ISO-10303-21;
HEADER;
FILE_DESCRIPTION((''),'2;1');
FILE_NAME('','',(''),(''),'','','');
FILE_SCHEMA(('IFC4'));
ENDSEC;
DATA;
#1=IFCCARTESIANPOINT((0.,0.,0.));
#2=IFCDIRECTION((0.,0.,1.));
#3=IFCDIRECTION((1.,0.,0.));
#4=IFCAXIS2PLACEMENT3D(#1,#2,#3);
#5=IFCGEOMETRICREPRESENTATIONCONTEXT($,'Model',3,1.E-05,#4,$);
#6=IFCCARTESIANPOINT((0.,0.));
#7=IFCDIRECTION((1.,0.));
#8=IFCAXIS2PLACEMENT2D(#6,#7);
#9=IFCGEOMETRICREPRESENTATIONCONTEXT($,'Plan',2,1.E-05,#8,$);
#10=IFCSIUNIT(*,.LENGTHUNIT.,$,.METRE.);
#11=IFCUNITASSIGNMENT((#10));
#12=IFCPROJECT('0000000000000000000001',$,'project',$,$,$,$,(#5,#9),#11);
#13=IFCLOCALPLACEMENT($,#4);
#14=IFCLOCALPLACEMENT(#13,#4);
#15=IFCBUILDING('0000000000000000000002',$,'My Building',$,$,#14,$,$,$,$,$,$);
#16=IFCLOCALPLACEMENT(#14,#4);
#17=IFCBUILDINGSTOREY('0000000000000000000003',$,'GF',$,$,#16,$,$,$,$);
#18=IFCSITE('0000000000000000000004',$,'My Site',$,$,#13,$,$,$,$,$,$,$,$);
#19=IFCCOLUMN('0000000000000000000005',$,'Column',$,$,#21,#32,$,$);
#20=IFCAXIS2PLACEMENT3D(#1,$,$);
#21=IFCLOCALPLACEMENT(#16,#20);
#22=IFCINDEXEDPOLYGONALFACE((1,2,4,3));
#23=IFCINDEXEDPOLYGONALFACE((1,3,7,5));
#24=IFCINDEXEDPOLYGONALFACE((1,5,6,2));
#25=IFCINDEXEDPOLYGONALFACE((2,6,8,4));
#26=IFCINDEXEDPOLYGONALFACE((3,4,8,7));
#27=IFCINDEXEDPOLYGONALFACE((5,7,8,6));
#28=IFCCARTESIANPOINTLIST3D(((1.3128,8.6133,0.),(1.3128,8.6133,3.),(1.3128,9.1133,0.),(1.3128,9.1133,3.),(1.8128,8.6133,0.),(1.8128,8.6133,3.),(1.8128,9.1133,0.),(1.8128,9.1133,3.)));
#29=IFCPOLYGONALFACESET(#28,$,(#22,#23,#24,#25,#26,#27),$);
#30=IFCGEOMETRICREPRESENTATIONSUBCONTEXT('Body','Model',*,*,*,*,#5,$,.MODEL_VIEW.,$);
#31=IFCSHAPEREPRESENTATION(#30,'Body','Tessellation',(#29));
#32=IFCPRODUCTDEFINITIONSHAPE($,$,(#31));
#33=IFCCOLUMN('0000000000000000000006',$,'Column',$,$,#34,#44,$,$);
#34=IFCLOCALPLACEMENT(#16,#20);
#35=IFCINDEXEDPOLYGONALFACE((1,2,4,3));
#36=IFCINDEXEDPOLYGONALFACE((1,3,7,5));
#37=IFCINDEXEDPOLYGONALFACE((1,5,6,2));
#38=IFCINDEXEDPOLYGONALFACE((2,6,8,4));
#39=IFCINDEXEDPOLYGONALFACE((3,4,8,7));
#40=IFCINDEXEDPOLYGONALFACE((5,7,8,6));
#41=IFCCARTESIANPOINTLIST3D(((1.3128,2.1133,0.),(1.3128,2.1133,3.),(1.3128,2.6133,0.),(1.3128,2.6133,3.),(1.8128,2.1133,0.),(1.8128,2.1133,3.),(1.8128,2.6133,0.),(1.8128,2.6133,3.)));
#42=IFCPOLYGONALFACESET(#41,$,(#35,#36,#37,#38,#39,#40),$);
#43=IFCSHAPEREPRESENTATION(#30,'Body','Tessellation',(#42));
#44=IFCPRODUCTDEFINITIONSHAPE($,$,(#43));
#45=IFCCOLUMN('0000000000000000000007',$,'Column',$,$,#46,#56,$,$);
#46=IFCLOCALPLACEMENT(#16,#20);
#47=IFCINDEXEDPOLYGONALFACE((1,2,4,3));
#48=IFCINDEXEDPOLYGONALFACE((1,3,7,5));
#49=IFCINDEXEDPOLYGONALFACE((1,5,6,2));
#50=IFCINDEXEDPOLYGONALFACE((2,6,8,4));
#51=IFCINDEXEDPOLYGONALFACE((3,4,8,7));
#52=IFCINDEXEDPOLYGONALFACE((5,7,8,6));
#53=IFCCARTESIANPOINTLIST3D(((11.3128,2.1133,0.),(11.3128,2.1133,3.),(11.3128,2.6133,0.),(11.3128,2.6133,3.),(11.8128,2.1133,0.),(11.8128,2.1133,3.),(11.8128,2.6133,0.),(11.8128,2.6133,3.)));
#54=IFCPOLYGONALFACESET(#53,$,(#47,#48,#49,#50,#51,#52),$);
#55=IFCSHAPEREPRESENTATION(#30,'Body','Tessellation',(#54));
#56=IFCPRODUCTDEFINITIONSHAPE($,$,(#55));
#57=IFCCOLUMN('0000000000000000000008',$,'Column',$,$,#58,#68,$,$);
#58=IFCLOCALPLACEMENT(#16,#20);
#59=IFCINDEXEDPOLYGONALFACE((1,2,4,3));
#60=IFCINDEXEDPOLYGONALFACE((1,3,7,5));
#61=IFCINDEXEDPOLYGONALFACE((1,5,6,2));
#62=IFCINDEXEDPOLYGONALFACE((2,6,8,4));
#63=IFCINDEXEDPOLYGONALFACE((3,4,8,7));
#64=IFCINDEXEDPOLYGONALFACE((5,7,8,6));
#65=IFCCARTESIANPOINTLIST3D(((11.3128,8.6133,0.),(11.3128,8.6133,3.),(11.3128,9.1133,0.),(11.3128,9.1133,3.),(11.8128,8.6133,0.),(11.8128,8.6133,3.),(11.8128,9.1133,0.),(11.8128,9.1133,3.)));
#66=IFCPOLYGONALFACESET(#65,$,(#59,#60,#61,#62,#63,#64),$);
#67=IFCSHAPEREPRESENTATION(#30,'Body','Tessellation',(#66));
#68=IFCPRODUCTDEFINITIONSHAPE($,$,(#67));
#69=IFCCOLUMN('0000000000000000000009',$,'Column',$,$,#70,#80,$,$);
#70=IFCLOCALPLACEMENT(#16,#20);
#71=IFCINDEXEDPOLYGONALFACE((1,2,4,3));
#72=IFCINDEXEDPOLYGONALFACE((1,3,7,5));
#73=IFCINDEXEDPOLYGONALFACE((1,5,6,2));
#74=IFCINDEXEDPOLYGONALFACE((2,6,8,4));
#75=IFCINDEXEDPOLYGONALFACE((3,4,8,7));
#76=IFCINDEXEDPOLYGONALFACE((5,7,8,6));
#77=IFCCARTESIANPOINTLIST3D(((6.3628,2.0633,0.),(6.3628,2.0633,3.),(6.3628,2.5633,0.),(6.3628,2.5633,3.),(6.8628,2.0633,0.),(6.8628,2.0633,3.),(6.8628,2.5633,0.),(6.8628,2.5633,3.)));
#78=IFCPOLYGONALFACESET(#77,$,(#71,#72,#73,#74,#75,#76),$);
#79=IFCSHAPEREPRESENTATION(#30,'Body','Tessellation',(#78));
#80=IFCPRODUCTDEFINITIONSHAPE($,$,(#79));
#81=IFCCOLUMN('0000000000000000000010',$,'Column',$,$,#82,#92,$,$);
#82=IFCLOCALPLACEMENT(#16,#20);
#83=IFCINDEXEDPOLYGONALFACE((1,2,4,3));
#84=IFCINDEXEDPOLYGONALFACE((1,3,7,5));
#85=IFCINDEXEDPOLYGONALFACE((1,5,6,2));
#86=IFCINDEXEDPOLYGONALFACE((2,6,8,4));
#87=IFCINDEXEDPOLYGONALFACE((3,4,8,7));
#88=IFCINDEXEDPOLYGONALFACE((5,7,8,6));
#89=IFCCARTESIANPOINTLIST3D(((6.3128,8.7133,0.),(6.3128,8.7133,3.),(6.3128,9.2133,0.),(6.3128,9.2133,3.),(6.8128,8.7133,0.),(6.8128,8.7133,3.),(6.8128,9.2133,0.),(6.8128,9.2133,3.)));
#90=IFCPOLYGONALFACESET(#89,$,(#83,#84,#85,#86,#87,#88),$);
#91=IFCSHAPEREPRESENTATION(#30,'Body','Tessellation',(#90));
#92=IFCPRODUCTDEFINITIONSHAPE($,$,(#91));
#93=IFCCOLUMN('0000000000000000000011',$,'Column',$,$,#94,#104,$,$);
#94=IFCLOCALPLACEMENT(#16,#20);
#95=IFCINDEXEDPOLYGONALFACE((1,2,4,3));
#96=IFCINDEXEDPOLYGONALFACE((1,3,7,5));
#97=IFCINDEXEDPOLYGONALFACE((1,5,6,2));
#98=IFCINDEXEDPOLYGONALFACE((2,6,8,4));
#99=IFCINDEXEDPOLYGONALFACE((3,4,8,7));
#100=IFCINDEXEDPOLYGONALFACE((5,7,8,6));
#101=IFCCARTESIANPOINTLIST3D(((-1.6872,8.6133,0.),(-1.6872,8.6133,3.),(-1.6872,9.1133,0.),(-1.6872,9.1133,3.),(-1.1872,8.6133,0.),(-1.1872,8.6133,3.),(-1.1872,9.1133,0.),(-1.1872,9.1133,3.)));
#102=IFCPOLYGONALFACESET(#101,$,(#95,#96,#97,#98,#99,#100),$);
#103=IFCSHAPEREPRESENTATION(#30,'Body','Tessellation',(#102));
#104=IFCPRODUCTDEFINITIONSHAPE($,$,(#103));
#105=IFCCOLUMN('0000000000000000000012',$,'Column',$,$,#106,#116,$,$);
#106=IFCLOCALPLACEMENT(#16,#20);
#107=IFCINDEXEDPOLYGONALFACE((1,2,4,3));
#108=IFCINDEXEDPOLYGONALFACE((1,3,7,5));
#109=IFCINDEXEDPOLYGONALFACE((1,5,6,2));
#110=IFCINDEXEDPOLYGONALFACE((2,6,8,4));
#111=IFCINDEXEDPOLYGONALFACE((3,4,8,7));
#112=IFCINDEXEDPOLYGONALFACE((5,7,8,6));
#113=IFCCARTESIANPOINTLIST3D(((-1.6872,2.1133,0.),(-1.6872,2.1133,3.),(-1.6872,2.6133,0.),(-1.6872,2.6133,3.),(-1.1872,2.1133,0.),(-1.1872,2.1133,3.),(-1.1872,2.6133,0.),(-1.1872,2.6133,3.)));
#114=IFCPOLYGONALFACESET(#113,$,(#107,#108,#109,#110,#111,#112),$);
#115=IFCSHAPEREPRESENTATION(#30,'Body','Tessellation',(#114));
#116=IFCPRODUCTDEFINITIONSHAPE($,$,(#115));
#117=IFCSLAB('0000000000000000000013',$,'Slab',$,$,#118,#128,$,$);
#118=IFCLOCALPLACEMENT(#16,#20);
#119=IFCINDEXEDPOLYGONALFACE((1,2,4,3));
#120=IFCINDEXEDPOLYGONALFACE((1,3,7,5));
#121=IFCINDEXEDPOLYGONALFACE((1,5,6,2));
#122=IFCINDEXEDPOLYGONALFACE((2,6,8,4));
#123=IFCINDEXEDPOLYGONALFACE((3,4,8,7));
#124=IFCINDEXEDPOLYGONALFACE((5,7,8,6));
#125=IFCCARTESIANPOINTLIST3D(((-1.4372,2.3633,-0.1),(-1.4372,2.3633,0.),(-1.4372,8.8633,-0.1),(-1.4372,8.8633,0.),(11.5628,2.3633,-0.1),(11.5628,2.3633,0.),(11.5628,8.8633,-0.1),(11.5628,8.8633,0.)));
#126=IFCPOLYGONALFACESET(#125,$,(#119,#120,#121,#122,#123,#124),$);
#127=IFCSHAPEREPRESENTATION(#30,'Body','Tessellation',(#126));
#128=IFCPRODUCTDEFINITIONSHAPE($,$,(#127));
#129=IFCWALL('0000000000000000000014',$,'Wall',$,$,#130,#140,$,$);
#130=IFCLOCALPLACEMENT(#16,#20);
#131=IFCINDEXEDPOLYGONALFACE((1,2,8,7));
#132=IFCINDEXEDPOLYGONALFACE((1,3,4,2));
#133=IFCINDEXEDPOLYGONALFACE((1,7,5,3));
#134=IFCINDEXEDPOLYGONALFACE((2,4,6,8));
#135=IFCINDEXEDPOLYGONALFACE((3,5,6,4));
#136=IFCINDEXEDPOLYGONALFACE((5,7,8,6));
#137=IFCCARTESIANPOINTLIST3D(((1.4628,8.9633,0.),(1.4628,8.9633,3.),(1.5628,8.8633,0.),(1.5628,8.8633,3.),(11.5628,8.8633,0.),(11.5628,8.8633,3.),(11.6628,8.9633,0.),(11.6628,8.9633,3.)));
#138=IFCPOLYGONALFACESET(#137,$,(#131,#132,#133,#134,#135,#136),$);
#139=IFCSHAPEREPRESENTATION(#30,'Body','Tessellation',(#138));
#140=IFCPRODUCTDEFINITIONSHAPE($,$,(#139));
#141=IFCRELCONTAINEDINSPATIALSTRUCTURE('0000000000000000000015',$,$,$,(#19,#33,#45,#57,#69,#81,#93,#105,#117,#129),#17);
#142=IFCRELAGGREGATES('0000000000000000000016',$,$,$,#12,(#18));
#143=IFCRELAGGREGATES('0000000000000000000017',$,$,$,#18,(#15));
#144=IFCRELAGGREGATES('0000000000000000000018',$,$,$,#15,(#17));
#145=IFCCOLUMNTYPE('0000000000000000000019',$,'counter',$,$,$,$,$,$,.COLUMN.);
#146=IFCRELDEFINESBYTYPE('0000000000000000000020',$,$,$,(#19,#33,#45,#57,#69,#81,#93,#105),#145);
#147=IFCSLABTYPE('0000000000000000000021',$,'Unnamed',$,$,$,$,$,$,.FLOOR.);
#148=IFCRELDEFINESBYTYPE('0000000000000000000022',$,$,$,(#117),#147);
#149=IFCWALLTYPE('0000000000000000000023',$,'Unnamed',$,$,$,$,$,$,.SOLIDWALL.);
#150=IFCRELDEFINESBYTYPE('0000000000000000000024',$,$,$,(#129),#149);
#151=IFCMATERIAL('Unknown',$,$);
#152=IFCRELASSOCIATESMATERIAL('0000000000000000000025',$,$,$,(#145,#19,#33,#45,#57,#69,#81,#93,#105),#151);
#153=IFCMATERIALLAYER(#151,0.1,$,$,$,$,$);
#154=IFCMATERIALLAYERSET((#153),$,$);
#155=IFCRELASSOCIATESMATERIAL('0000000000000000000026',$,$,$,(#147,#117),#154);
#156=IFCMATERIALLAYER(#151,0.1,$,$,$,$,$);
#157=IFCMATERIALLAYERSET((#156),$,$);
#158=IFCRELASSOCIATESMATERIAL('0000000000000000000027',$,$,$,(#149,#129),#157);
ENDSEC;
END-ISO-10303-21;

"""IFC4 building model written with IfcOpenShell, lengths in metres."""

from ifc_helpers import new_model, si_unit, frame, origin_with_axes, origin_2d_with_axis, place, context, subcontext, project, spatial, line, indexed_curve, rectangle, outline, extrude, material, layer, layer_set, layer_usage, material_profile, profile_set, profile_usage, type_object, element, save


model = new_model("IFC4")

# Units and contexts
model_context = context("Model", 3, precision=1e-05, world=origin_with_axes())
plan_context = context("Plan", 2, precision=1e-05, world=origin_2d_with_axis())
body_context_1 = subcontext(model_context, "Body", "Model", "MODEL_VIEW")
ifc_project = project(units=[si_unit("LENGTHUNIT", "METRE")], contexts=[model_context, plan_context])

# Site, building, storey
site_placement = place(None, origin_with_axes())
site = spatial("IfcSite", under=ifc_project, at=site_placement, Name="My Site")
building_placement = place(site_placement, origin_with_axes())
building = spatial("IfcBuilding", under=site, at=building_placement, Name="My Building")
storey_placement = place(building_placement, origin_with_axes())
storey = spatial("IfcBuildingStorey", under=building, at=storey_placement, Name="GF")

# Columns
ifc_material = material(Name="Unknown")
ifc_material_profile = material_profile(ifc_material, rectangle(XDim=0.5, YDim=0.5))
ifc_profile_set = profile_set([ifc_material_profile])
ifc_profile_usage_1 = profile_usage(ifc_profile_set, cardinal=5)
column_type = type_object("IfcColumnType", Name="counter", PredefinedType="COLUMN", material=ifc_profile_set)
column_1_placement = place(storey_placement, frame((1.5628, 8.8633, 0.0), z_axis=(0.0, 0.0, 1.0), x_axis=(1.0, 0.0, 0.0)))
element("IfcColumn", 1, at=column_1_placement, inside=storey, type_object=column_type, material=ifc_profile_usage_1, Name="Column", context=body_context_1, shape_type="SweptSolid", body=[
    extrude(rectangle(XDim=0.5, YDim=0.5), origin_with_axes(), (0.0, 0.0, 1.0), 3.0),
])
ifc_profile_usage_2 = profile_usage(ifc_profile_set, cardinal=5)
column_2_placement = place(storey_placement, frame((1.5628, 2.3633, 0.0), z_axis=(0.0, 0.0, 1.0), x_axis=(1.0, 0.0, 0.0)))
element("IfcColumn", 2, at=column_2_placement, inside=storey, type_object=column_type, material=ifc_profile_usage_2, Name="Column", context=body_context_1, shape_type="SweptSolid", body=[
    extrude(rectangle(XDim=0.5, YDim=0.5), origin_with_axes(), (0.0, 0.0, 1.0), 3.0),
])
ifc_profile_usage_3 = profile_usage(ifc_profile_set, cardinal=5)
column_3_placement = place(storey_placement, frame((11.5628, 2.3633, 0.0), z_axis=(0.0, 0.0, 1.0), x_axis=(1.0, 0.0, 0.0)))
element("IfcColumn", 3, at=column_3_placement, inside=storey, type_object=column_type, material=ifc_profile_usage_3, Name="Column", context=body_context_1, shape_type="SweptSolid", body=[
    extrude(rectangle(XDim=0.5, YDim=0.5), origin_with_axes(), (0.0, 0.0, 1.0), 3.0),
])
ifc_profile_usage_4 = profile_usage(ifc_profile_set, cardinal=5)
column_4_placement = place(storey_placement, frame((11.5628, 8.8633, 0.0), z_axis=(0.0, 0.0, 1.0), x_axis=(1.0, 0.0, 0.0)))
element("IfcColumn", 4, at=column_4_placement, inside=storey, type_object=column_type, material=ifc_profile_usage_4, Name="Column", context=body_context_1, shape_type="SweptSolid", body=[
    extrude(rectangle(XDim=0.5, YDim=0.5), origin_with_axes(), (0.0, 0.0, 1.0), 3.0),
])
ifc_profile_usage_5 = profile_usage(ifc_profile_set, cardinal=5)
column_5_placement = place(storey_placement, frame((6.6128, 2.3133, 0.0), z_axis=(0.0, 0.0, 1.0), x_axis=(1.0, 0.0, 0.0)))
element("IfcColumn", 5, at=column_5_placement, inside=storey, type_object=column_type, material=ifc_profile_usage_5, Name="Column", context=body_context_1, shape_type="SweptSolid", body=[
    extrude(rectangle(XDim=0.5, YDim=0.5), origin_with_axes(), (0.0, 0.0, 1.0), 3.0),
])
ifc_profile_usage_6 = profile_usage(ifc_profile_set, cardinal=5)
column_6_placement = place(storey_placement, frame((6.5628, 8.9633, 0.0), z_axis=(0.0, 0.0, 1.0), x_axis=(1.0, 0.0, 0.0)))
element("IfcColumn", 6, at=column_6_placement, inside=storey, type_object=column_type, material=ifc_profile_usage_6, Name="Column", context=body_context_1, shape_type="SweptSolid", body=[
    extrude(rectangle(XDim=0.5, YDim=0.5), origin_with_axes(), (0.0, 0.0, 1.0), 3.0),
])
ifc_profile_usage_7 = profile_usage(ifc_profile_set, cardinal=5)
column_7_placement = place(storey_placement, frame((-1.4372, 8.8633, 0.0), z_axis=(0.0, 0.0, 1.0), x_axis=(1.0, 0.0, 0.0)))
element("IfcColumn", 7, at=column_7_placement, inside=storey, type_object=column_type, material=ifc_profile_usage_7, Name="Column", context=body_context_1, shape_type="SweptSolid", body=[
    extrude(rectangle(XDim=0.5, YDim=0.5), origin_with_axes(), (0.0, 0.0, 1.0), 3.0),
])
ifc_profile_usage_8 = profile_usage(ifc_profile_set, cardinal=5)
column_8_placement = place(storey_placement, frame((-1.4372, 2.3633, 0.0), z_axis=(0.0, 0.0, 1.0), x_axis=(1.0, 0.0, 0.0)))
element("IfcColumn", 8, at=column_8_placement, inside=storey, type_object=column_type, material=ifc_profile_usage_8, Name="Column", context=body_context_1, shape_type="SweptSolid", body=[
    extrude(rectangle(XDim=0.5, YDim=0.5), origin_with_axes(), (0.0, 0.0, 1.0), 3.0),
])

# Slab
ifc_layer_1 = layer(ifc_material, 0.1)
ifc_layer_set_1 = layer_set([ifc_layer_1])
ifc_layer_usage_1 = layer_usage(ifc_layer_set_1, "AXIS3", "POSITIVE", -0.1)
slab_type = type_object("IfcSlabType", Name="Unnamed", PredefinedType="FLOOR", material=ifc_layer_set_1)
slab_placement = place(storey_placement, frame((11.5628, 8.8633, 0.0), z_axis=(0.0, 0.0, 1.0), x_axis=(1.0, 0.0, 0.0)))
element("IfcSlab", 9, at=slab_placement, inside=storey, type_object=slab_type, material=ifc_layer_usage_1, Name="Slab", context=body_context_1, shape_type="SweptSolid", body=[
    extrude(outline(indexed_curve([(0.0, 0.0), (-13.0, 0.0), (-13.0, -6.5), (0.0, -6.5), (0.0, 0.0)])), frame((0.0, 0.0, -0.1), z_axis=(0.0, 0.0, 1.0), x_axis=(1.0, 0.0, 0.0)), (0.0, 0.0, 1.0), 0.1),
])

# Wall
ifc_layer_2 = layer(ifc_material, 0.1)
ifc_layer_set_2 = layer_set([ifc_layer_2])
ifc_layer_usage_2 = layer_usage(ifc_layer_set_2, "AXIS2", "POSITIVE", 0.0)
wall_type = type_object("IfcWallType", Name="Unnamed", PredefinedType="SOLIDWALL", material=ifc_layer_set_2)
wall_1_placement = place(storey_placement, frame((1.5628, 8.8633, 0.0), z_axis=(0.0, 0.0, 1.0), x_axis=(1.0, 0.0, 0.0)))
element("IfcWall", 10, at=wall_1_placement, inside=storey, type_object=wall_type, material=ifc_layer_usage_2, Name="Wall", context=body_context_1, shape_type="SweptSolid", body=[
    extrude(outline(indexed_curve([(0.0, 0.0), (-0.1, 0.1), (10.1, 0.1), (10.0, 0.0)], segments=[line(1, 2, 3, 4, 1)])), origin_with_axes(), (0.0, 0.0, 1.0), 3.0),
])

save(model, "model.ifc")
